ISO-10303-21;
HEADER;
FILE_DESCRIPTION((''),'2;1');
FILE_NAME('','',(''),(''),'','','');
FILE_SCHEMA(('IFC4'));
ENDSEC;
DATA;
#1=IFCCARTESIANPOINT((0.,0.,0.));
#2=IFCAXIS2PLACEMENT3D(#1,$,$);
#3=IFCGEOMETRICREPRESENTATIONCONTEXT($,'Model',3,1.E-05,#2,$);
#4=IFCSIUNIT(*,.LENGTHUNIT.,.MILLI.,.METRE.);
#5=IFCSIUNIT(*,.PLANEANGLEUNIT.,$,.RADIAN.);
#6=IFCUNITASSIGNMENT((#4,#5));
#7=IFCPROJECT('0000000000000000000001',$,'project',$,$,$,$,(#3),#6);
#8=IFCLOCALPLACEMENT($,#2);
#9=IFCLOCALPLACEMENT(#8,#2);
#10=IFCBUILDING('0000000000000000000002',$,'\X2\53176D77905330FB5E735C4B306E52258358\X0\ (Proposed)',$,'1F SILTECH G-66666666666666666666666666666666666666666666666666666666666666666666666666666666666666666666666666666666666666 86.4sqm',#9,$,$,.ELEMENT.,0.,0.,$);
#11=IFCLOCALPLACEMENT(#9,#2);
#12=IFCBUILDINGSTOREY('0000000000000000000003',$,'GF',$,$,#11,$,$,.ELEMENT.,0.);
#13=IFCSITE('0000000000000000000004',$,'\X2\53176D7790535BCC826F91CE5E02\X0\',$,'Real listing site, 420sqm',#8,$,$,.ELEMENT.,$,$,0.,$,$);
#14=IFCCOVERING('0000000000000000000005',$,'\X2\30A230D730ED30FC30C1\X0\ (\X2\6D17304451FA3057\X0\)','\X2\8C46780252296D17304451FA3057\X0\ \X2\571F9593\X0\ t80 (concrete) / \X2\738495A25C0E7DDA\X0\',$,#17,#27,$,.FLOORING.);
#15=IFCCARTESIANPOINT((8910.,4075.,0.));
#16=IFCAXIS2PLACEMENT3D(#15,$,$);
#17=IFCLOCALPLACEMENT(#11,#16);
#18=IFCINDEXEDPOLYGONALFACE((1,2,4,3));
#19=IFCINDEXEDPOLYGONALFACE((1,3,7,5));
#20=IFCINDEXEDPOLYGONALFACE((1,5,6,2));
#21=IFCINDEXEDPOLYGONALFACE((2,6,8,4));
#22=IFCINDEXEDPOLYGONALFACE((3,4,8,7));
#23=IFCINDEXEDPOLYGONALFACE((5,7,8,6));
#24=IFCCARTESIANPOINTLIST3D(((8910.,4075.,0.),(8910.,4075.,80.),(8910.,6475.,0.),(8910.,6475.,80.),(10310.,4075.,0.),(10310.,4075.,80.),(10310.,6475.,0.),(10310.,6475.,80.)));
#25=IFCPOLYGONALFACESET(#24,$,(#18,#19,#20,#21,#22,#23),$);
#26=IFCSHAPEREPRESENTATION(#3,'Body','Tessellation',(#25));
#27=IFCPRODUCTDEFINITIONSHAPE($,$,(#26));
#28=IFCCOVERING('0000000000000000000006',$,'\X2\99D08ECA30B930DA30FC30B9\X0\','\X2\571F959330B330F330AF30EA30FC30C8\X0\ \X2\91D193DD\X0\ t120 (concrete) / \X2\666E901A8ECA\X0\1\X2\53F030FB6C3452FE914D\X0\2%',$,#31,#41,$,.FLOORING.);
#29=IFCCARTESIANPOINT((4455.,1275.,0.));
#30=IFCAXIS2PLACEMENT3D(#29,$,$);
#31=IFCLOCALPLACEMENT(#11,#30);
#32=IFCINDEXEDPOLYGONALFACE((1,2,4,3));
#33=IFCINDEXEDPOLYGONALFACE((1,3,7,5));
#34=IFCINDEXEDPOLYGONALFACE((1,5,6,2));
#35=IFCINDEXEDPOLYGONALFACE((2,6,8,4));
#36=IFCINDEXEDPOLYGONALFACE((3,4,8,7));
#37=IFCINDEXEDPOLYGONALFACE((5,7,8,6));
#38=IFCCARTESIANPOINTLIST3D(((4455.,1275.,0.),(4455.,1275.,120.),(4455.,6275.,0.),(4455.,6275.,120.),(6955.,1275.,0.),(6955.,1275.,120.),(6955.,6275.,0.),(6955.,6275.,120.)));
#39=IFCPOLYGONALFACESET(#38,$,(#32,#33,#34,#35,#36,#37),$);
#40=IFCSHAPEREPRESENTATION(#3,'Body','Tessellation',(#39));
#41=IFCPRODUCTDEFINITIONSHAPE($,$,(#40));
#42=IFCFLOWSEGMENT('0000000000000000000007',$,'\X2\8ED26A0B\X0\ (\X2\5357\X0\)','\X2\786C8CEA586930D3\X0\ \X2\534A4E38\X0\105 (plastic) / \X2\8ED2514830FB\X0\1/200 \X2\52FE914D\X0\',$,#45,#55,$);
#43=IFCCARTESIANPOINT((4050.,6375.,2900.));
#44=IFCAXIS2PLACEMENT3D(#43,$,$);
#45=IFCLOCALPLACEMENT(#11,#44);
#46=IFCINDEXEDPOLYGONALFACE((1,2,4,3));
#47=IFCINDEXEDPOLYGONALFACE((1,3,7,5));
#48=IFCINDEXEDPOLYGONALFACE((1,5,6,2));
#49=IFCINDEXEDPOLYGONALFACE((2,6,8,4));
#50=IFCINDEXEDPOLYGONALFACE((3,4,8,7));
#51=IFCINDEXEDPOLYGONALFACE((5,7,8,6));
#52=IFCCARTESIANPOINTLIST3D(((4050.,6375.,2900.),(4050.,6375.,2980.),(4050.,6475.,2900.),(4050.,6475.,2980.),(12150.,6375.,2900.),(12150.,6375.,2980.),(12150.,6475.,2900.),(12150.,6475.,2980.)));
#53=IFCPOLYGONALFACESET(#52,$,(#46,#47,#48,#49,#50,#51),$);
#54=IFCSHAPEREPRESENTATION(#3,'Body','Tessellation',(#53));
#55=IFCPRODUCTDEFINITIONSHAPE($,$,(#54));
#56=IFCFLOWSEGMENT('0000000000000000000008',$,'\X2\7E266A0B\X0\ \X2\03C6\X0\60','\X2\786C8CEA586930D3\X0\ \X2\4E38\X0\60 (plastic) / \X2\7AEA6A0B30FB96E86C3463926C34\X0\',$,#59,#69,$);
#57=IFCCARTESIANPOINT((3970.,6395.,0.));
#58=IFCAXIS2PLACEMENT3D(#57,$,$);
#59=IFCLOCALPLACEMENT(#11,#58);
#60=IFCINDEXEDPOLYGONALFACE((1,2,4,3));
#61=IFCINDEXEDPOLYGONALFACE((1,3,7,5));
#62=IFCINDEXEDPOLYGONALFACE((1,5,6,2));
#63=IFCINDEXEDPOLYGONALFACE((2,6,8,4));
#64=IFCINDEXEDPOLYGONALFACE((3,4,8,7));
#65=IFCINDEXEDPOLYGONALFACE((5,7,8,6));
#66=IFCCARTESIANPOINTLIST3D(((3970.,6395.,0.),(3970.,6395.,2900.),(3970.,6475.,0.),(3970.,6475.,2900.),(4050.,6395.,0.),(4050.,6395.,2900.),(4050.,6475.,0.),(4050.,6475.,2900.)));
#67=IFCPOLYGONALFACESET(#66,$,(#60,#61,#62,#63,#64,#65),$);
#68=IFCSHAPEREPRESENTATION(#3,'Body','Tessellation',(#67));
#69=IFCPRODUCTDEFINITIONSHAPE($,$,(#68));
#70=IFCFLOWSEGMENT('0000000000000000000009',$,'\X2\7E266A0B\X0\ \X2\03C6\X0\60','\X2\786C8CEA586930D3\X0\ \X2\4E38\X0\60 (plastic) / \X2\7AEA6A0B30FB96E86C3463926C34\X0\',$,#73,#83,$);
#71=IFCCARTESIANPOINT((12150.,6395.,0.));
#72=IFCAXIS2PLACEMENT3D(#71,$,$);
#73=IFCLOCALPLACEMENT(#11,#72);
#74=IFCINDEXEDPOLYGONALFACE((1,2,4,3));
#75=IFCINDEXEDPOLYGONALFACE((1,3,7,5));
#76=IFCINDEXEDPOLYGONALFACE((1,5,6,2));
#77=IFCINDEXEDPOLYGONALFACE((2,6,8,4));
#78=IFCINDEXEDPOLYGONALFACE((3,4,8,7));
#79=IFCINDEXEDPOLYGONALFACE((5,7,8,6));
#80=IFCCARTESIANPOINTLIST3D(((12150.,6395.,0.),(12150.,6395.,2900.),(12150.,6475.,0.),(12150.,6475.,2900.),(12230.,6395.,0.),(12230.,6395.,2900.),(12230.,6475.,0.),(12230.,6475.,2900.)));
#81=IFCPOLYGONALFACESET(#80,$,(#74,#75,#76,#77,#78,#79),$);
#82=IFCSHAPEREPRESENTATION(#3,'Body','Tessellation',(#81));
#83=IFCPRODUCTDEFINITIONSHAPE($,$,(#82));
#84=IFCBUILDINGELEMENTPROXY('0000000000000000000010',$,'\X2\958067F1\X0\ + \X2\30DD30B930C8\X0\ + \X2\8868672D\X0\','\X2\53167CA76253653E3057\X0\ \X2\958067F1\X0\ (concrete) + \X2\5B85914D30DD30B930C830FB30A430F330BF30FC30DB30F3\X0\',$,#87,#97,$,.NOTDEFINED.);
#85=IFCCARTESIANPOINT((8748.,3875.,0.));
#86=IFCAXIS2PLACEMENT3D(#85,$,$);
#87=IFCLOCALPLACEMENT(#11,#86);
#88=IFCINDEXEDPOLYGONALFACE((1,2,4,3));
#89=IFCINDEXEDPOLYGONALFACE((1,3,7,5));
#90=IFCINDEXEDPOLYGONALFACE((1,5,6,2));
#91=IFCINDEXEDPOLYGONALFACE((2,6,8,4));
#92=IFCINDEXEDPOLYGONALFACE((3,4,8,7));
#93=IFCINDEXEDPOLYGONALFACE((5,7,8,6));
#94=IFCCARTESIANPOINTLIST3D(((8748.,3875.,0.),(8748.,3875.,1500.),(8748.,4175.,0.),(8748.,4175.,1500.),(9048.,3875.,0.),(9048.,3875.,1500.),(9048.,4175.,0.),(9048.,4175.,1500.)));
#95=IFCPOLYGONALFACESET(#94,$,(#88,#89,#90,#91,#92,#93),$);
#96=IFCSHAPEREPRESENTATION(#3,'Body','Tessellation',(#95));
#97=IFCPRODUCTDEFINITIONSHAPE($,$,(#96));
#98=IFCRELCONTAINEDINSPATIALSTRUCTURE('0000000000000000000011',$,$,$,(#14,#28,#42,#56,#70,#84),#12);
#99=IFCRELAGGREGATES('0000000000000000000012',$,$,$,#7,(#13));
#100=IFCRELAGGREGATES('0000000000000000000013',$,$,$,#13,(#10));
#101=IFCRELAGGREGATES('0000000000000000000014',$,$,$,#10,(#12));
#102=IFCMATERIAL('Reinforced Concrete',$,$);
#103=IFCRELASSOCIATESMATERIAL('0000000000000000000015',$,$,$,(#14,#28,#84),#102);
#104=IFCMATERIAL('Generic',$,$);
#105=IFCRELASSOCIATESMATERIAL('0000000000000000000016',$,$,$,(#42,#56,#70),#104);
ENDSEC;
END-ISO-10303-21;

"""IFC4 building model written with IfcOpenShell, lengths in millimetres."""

from ifc_helpers import new_model, si_unit, frame, frame_2d, origin, place, context, project, spatial, rectangle, extrude, material, element, save


model = new_model("IFC4")

# Units and contexts
model_context = context("Model", 3, precision=1e-05, world=origin())
ifc_project = project(units=[si_unit("LENGTHUNIT", "METRE", prefix="MILLI"), si_unit("PLANEANGLEUNIT", "RADIAN")], contexts=[model_context])

# Site, building, storey
site_placement = place(None, origin())
site = spatial("IfcSite", under=ifc_project, at=site_placement, Name="北海道富良野市", ObjectType="Real listing site, 420sqm", CompositionType="ELEMENT", RefElevation=0.0)
building_placement = place(site_placement, origin())
building = spatial("IfcBuilding", under=site, at=building_placement, Name="北海道・平屋の別荘 (Proposed)", ObjectType="1F SILTECH G-66666666666666666666666666666666666666666666666666666666666666666666666666666666666666666666666666666666666666 86.4sqm", CompositionType="ELEMENT", ElevationOfRefHeight=0.0, ElevationOfTerrain=0.0)
storey_placement = place(building_placement, origin())
storey = spatial("IfcBuildingStorey", under=building, at=storey_placement, Name="GF", CompositionType="ELEMENT", Elevation=0.0)

# Shared definitions
ifc_material_1 = material(Name="Reinforced Concrete")

# Coverings
ifc_material_2 = material(Name="Generic")
covering_1_placement = place(storey_placement, frame((8910.0, 4075.0, 0.0)))
element("IfcCovering", 1, at=covering_1_placement, inside=storey, material=ifc_material_1, Name="アプローチ (洗い出し)", Description="豆砂利洗い出し 土間 t80 (concrete) / 玄関導線", PredefinedType="FLOORING", context=model_context, shape_type="SweptSolid", body=[
    extrude(rectangle(XDim=1400.0, YDim=2400.0, at=frame_2d((700.0, 1200.0))), frame((8910.0, 4075.0, 0.0)), (0.0, 0.0, 1.0), 80.0),
])
covering_2_placement = place(storey_placement, frame((4455.0, 1275.0, 0.0)))
element("IfcCovering", 2, at=covering_2_placement, inside=storey, material=ifc_material_1, Name="駐車スペース", Description="土間コンクリート 金鏝 t120 (concrete) / 普通車1台・水勾配2%", PredefinedType="FLOORING", context=model_context, shape_type="SweptSolid", body=[
    extrude(rectangle(XDim=2500.0, YDim=5000.0, at=frame_2d((1250.0, 2500.0))), frame((4455.0, 1275.0, 0.0)), (0.0, 0.0, 1.0), 120.0),
])

# Flow segments
flow_segment_1_placement = place(storey_placement, frame((4050.0, 6375.0, 2900.0)))
element("IfcFlowSegment", 3, at=flow_segment_1_placement, inside=storey, material=ifc_material_2, Name="軒樋 (南)", Description="硬質塩ビ 半丸105 (plastic) / 軒先・1/200 勾配", context=model_context, shape_type="SweptSolid", body=[
    extrude(rectangle(XDim=8100.0, YDim=100.0, at=frame_2d((4050.0, 50.0))), frame((4050.0, 6375.0, 2900.0)), (0.0, 0.0, 1.0), 80.0),
])
flow_segment_2_placement = place(storey_placement, frame((3970.0, 6395.0, 0.0)))
element("IfcFlowSegment", 4, at=flow_segment_2_placement, inside=storey, material=ifc_material_2, Name="縦樋 φ60", Description="硬質塩ビ 丸60 (plastic) / 竪樋・雨水排水", context=model_context, shape_type="SweptSolid", body=[
    extrude(rectangle(XDim=80.0, YDim=80.0, at=frame_2d((40.0, 40.0))), frame((3970.0, 6395.0, 0.0)), (0.0, 0.0, 1.0), 2900.0),
])
flow_segment_3_placement = place(storey_placement, frame((12150.0, 6395.0, 0.0)))
element("IfcFlowSegment", 5, at=flow_segment_3_placement, inside=storey, material=ifc_material_2, Name="縦樋 φ60", Description="硬質塩ビ 丸60 (plastic) / 竪樋・雨水排水", context=model_context, shape_type="SweptSolid", body=[
    extrude(rectangle(XDim=80.0, YDim=80.0, at=frame_2d((40.0, 40.0))), frame((12150.0, 6395.0, 0.0)), (0.0, 0.0, 1.0), 2900.0),
])

# Building element proxy
proxy_placement = place(storey_placement, frame((8748.0, 3875.0, 0.0)))
element("IfcBuildingElementProxy", 6, at=proxy_placement, inside=storey, material=ifc_material_1, Name="門柱 + ポスト + 表札", Description="化粧打放し 門柱 (concrete) + 宅配ポスト・インターホン", PredefinedType="NOTDEFINED", context=model_context, shape_type="SweptSolid", body=[
    extrude(rectangle(XDim=300.0, YDim=300.0, at=frame_2d((150.0, 150.0))), frame((8748.0, 3875.0, 0.0)), (0.0, 0.0, 1.0), 1500.0),
])

save(model, "model.ifc")
